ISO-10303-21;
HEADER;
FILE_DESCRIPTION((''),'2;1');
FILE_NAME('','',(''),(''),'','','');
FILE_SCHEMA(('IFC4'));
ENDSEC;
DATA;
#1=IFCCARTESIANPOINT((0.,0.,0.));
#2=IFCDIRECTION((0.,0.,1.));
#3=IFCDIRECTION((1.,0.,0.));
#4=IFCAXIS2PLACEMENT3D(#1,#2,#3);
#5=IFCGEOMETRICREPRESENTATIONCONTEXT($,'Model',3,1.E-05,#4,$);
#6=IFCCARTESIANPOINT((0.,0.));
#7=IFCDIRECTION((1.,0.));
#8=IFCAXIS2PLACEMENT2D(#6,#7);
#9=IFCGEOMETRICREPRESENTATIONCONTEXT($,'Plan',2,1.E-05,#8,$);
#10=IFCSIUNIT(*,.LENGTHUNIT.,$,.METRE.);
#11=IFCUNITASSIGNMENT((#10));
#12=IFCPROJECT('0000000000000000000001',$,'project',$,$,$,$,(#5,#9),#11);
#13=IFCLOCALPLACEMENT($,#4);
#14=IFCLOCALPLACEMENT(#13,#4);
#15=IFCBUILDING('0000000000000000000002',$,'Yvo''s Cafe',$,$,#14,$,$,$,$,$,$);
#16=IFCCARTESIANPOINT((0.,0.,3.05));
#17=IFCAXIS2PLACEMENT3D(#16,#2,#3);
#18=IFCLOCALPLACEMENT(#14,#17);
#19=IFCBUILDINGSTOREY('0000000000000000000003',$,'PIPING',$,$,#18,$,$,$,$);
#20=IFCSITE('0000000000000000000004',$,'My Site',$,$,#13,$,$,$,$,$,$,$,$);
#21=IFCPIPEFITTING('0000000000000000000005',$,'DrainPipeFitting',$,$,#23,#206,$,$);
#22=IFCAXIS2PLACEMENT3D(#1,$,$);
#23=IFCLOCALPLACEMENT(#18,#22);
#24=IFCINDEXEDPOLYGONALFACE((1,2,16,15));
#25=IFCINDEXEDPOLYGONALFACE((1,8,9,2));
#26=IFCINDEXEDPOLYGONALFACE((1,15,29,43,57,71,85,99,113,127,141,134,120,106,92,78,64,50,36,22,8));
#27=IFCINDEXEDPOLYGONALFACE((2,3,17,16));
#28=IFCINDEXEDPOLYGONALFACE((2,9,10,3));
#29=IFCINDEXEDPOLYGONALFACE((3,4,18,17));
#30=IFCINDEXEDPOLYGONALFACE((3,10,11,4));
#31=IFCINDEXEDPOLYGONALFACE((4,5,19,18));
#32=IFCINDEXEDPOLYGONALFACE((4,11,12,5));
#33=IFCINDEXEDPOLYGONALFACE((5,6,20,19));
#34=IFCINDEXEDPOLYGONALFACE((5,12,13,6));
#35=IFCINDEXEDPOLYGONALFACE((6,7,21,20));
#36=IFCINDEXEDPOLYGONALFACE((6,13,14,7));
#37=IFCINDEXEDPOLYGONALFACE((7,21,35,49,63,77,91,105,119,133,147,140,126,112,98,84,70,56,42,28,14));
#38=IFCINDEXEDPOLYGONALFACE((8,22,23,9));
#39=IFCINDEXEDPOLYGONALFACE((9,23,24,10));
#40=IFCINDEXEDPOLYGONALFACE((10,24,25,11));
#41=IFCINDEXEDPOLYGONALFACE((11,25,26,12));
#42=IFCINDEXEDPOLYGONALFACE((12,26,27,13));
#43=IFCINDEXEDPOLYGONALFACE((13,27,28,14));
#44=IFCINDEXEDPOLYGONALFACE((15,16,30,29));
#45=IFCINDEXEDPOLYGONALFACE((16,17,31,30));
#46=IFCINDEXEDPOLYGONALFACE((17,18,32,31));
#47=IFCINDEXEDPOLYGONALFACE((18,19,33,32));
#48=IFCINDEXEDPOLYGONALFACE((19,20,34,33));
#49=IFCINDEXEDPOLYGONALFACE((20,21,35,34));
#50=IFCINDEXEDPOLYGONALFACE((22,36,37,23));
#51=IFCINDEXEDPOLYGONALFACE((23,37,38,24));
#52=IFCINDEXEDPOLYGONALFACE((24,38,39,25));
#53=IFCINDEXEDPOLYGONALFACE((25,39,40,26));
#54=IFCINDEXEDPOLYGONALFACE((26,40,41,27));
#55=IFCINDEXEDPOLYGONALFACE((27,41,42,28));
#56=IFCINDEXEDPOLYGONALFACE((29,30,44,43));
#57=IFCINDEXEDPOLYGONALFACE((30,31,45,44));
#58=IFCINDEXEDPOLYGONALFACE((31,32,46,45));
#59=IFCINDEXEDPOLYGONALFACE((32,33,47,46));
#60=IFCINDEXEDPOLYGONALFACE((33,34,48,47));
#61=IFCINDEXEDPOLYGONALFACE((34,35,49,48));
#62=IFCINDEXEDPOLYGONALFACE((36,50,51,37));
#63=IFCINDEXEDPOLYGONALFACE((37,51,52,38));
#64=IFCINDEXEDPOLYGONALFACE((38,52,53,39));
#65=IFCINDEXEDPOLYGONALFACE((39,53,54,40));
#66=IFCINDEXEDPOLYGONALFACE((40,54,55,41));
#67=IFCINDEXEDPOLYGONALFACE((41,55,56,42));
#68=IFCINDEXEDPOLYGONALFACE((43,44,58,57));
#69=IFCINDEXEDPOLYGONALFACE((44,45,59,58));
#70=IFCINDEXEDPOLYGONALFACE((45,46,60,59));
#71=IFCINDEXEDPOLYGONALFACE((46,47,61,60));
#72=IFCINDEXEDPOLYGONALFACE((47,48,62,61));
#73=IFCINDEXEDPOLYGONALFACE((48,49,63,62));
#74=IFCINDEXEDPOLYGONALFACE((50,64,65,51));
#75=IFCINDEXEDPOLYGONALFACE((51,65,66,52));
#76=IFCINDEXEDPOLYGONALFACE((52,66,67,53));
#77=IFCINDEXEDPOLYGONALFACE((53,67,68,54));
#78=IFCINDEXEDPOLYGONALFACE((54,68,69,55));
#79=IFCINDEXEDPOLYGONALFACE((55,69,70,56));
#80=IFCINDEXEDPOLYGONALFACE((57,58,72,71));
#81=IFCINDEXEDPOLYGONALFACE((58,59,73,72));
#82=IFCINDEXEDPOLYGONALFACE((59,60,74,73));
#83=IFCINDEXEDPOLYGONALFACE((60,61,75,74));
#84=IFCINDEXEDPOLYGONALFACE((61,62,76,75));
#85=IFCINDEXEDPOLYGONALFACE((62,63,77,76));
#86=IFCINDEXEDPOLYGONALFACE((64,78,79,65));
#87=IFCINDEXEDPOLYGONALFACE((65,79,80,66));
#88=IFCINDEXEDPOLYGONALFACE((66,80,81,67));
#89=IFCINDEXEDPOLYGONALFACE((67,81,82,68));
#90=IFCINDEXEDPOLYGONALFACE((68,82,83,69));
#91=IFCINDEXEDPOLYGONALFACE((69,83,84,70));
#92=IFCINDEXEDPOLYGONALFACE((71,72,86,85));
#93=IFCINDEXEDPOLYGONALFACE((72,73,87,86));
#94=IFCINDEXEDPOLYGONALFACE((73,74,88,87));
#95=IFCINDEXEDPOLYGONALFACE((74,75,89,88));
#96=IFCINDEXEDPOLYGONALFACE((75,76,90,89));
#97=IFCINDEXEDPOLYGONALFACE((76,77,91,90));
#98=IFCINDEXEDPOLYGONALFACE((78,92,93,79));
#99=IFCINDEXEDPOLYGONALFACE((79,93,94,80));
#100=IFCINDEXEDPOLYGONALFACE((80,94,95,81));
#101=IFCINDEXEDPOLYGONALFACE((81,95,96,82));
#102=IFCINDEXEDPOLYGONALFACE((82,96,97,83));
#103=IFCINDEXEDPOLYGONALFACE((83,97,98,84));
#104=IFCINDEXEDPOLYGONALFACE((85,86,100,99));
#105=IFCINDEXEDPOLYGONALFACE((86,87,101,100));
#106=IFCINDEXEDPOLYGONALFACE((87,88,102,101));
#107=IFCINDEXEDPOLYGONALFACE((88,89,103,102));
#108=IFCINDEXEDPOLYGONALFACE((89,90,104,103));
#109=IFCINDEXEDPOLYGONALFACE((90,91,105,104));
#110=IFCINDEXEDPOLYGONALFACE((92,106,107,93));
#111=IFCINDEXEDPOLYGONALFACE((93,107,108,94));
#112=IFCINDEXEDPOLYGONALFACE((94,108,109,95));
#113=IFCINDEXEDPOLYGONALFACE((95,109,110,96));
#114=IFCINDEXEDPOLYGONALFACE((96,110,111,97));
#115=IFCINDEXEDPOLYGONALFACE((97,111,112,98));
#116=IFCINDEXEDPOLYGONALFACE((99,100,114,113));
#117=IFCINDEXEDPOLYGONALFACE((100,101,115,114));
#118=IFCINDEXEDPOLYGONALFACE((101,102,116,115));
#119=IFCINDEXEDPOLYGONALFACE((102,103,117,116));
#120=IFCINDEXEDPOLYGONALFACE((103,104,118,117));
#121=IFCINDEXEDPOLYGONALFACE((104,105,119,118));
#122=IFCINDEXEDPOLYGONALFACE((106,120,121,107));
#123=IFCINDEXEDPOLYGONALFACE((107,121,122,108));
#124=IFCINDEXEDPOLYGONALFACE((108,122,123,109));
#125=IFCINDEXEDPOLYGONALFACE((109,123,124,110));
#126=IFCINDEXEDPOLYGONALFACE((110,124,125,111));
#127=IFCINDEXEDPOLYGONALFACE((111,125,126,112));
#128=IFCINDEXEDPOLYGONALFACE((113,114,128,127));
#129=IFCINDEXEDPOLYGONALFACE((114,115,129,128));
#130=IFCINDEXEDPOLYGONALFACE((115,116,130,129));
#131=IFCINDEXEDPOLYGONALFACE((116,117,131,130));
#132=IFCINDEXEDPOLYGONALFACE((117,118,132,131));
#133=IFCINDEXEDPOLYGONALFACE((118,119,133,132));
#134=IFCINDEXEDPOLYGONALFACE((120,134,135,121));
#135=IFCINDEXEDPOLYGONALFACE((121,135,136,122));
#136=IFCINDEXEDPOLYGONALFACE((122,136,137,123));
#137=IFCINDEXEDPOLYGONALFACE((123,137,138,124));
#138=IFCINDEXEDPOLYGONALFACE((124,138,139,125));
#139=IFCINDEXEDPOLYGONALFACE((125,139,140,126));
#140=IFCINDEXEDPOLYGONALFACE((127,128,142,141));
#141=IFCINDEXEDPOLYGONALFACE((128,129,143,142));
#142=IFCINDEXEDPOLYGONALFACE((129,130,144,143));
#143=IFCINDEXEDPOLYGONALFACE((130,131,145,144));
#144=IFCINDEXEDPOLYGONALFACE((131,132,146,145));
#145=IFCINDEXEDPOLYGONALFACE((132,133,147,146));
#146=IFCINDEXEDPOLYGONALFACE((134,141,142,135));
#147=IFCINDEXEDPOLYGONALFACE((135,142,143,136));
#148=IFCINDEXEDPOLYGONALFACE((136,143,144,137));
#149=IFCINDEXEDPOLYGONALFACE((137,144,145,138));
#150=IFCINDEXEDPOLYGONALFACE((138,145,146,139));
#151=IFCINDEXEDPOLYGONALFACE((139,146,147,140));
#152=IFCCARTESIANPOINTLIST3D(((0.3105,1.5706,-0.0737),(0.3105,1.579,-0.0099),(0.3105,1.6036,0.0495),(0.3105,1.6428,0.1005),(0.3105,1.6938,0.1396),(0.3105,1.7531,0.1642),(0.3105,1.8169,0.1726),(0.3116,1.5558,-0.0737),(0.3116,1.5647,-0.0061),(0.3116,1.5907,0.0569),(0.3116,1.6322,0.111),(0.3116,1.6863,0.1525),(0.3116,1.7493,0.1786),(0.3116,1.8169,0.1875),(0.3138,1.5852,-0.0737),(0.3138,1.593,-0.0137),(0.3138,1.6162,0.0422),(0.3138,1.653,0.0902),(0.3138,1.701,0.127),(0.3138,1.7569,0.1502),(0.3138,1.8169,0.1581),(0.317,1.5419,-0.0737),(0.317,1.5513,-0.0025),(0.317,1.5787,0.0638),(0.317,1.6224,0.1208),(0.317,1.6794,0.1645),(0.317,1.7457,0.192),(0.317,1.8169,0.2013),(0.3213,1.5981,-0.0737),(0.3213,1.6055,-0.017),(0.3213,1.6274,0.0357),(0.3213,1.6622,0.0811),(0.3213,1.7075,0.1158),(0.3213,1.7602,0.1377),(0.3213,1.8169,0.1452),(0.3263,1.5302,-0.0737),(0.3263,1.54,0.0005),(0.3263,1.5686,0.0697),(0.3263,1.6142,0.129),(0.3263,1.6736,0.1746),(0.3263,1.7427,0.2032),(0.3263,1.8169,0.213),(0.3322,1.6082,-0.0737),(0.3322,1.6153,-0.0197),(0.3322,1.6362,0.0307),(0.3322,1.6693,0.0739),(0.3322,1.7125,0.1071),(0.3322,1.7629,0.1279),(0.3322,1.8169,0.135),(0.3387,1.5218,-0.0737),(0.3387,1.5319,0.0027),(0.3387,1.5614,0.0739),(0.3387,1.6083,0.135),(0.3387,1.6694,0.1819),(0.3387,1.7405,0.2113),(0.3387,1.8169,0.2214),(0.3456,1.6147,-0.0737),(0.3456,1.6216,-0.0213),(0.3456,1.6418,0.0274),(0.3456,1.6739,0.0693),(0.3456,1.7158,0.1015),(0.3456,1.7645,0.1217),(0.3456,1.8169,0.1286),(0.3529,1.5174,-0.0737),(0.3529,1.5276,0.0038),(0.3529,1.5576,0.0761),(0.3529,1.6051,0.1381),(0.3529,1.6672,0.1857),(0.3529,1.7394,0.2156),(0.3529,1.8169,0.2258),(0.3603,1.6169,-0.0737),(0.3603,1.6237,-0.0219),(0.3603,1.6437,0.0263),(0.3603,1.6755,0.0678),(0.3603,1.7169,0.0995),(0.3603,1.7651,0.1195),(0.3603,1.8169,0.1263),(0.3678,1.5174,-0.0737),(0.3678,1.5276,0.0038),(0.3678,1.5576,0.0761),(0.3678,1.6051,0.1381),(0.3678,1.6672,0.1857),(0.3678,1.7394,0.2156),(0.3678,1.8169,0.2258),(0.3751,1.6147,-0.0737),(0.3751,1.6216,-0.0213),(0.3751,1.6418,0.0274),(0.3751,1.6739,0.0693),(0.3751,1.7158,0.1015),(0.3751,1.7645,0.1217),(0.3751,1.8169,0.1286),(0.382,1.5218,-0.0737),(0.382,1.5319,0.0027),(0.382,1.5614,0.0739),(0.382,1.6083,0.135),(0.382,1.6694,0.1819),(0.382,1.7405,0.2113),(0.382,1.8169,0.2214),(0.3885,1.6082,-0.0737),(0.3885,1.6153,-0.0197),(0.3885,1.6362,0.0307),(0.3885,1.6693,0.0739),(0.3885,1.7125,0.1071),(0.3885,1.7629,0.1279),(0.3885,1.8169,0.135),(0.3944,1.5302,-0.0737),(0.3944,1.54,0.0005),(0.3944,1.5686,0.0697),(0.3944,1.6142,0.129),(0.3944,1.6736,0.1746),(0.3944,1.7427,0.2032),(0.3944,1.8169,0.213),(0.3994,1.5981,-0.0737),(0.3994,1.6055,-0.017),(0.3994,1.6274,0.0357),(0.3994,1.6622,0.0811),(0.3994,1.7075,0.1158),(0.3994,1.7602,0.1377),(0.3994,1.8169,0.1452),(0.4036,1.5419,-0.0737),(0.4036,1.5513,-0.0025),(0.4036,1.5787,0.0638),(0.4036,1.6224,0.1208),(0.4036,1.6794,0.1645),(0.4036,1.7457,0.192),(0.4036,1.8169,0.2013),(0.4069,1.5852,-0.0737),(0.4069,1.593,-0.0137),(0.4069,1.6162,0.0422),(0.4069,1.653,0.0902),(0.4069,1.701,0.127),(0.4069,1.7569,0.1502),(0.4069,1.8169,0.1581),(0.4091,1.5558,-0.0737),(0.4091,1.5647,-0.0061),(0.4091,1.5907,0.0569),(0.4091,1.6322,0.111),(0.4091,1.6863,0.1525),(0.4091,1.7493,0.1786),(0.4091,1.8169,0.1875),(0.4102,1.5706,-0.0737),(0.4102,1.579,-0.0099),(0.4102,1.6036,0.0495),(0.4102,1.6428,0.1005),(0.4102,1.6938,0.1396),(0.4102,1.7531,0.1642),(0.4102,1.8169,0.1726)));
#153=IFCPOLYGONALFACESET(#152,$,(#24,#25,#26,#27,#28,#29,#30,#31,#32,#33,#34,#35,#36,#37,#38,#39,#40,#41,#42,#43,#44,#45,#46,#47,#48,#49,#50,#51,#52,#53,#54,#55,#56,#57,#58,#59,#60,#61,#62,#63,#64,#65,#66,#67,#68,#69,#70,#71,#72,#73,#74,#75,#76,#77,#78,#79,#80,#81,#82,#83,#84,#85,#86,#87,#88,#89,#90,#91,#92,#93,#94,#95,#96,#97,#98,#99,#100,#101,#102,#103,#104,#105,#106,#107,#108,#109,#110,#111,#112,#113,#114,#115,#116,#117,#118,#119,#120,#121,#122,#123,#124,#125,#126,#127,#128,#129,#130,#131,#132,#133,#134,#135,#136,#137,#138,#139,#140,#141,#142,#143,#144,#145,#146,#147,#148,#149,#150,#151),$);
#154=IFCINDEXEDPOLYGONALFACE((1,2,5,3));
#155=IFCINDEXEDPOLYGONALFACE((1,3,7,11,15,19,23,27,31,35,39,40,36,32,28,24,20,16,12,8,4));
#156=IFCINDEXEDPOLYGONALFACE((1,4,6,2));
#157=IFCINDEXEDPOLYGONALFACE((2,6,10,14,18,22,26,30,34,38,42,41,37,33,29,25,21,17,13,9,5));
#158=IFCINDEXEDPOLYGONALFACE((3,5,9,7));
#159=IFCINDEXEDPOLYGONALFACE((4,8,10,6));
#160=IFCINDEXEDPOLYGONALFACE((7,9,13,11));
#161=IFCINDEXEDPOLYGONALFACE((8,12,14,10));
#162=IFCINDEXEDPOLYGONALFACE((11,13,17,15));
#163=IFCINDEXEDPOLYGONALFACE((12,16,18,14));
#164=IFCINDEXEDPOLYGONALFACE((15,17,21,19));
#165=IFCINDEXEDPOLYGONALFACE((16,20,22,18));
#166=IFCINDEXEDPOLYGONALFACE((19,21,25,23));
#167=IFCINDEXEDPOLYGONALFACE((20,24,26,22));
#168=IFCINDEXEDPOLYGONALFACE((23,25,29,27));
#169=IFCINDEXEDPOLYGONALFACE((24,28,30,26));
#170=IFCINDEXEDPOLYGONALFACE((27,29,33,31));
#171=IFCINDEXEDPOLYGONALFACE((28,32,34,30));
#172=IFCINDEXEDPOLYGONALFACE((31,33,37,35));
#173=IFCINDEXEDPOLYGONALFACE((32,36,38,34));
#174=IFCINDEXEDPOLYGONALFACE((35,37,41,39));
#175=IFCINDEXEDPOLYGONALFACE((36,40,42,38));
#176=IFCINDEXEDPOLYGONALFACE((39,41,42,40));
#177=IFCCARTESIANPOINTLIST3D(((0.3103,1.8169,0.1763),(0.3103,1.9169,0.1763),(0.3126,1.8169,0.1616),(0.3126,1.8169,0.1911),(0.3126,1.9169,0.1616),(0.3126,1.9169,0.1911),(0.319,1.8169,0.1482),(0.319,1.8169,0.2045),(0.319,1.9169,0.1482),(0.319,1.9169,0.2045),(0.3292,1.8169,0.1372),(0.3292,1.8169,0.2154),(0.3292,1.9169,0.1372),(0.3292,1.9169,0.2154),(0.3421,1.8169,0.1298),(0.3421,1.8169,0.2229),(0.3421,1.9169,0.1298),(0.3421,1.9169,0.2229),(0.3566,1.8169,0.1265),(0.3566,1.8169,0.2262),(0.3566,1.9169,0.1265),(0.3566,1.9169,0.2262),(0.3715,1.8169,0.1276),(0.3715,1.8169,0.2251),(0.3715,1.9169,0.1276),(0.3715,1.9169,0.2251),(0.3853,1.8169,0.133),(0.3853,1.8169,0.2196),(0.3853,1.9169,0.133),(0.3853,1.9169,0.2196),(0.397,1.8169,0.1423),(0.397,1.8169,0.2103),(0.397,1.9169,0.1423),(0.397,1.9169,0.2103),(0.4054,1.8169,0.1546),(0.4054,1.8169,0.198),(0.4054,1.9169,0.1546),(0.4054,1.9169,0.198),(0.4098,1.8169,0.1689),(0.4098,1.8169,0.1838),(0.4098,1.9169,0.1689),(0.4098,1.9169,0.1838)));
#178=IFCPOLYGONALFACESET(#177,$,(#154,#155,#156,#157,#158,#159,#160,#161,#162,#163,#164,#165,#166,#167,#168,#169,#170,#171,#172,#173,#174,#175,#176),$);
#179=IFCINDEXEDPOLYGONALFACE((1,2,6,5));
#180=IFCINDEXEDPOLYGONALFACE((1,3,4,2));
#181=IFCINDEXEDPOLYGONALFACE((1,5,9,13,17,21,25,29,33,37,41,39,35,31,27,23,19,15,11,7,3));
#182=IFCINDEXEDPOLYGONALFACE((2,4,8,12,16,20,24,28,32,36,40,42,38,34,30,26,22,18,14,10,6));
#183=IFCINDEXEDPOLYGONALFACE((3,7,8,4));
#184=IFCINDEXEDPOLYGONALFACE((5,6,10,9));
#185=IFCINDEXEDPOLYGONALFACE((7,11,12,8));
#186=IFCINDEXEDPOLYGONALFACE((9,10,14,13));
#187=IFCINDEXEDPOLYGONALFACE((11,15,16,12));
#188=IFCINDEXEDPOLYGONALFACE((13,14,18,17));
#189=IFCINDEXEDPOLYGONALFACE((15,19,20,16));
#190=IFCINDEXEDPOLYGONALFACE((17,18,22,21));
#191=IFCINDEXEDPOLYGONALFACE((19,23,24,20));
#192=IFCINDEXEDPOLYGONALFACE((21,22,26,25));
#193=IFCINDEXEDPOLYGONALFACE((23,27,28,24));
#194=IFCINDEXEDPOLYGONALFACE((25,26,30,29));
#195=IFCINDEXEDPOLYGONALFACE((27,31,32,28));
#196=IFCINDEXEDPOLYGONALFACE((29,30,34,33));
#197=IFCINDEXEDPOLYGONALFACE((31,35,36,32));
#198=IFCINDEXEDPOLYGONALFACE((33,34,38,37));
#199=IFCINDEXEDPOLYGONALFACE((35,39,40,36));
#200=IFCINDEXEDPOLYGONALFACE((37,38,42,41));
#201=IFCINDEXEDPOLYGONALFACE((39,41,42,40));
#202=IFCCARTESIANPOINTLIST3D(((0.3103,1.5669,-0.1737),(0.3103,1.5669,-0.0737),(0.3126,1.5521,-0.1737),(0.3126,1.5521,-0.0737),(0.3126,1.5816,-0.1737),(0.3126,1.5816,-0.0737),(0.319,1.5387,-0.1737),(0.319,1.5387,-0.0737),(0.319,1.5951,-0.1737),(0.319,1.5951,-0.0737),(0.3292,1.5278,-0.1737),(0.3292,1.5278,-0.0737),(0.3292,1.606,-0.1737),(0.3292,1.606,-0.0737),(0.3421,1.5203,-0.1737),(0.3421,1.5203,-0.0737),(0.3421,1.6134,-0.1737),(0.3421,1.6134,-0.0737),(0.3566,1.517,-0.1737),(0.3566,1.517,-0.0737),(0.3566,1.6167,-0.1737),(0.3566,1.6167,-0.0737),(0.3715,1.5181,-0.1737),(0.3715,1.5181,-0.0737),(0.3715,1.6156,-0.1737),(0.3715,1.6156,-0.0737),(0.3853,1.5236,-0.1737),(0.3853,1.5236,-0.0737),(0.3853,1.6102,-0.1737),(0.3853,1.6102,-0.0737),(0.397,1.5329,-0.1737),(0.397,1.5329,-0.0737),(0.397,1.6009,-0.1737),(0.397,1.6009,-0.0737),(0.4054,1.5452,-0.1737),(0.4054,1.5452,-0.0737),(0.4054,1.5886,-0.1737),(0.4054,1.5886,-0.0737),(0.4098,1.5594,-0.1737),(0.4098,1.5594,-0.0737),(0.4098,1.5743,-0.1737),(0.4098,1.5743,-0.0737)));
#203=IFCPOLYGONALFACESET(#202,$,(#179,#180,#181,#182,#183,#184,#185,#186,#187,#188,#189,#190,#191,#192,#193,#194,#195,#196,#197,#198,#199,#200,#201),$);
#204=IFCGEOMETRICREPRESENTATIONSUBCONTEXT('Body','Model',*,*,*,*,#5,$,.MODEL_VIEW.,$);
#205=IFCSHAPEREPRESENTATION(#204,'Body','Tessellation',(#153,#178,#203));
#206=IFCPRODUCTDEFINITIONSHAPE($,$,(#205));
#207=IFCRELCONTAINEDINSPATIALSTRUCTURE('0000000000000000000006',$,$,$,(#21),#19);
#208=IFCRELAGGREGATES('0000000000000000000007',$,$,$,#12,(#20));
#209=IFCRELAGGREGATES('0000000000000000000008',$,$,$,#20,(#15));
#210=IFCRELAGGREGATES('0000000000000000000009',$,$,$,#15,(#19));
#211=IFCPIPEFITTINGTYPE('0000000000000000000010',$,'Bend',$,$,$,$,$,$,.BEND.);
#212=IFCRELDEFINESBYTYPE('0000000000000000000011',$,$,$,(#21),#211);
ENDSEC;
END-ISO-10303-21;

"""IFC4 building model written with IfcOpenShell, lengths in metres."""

from ifc_helpers import new_model, entity, si_unit, frame, origin_with_axes, origin_2d_with_axis, place, context, subcontext, project, spatial, circle, extrude, source, transform, mapped, type_object, type_shapes, element, save


model = new_model("IFC4")

# Units and contexts
model_context = context("Model", 3, precision=1e-05, world=origin_with_axes())
plan_context = context("Plan", 2, precision=1e-05, world=origin_2d_with_axis())
body_context = subcontext(model_context, "Body", "Model", "MODEL_VIEW")
ifc_project = project(units=[si_unit("LENGTHUNIT", "METRE")], contexts=[model_context, plan_context])

# Site, building, storey
site_placement = place(None, origin_with_axes())
site = spatial("IfcSite", under=ifc_project, at=site_placement, Name="My Site")
building_placement = place(site_placement, origin_with_axes())
building = spatial("IfcBuilding", under=site, at=building_placement, Name="Yvo's Cafe")
storey_placement = place(building_placement, frame((0.0, 0.0, 3.05), z_axis=(0.0, 0.0, 1.0), x_axis=(1.0, 0.0, 0.0)))
storey = spatial("IfcBuildingStorey", under=building, at=storey_placement, Name="PIPING")

# Shared definitions
pipe_fitting_type_1 = type_object("IfcPipeFittingType", Name="Bend", PredefinedType="BEND")
shared_shape_1 = source(origin_with_axes(), body_context, "Body", "SolidModel", [
    entity("IfcSweptDiskSolid", entity("IfcIndexedPolyCurve", entity("IfcCartesianPointList3D", [[0.0, 0.0, -0.1], [0.0, -0.0732, -0.2768], [0.0, -0.25, -0.35]]), [entity("IfcArcIndex", [1, 2, 3])]), 0.05),
    extrude(circle(Radius=0.05), origin_with_axes(), (0.0, 0.0, -1.0), 0.1),
    extrude(circle(Radius=0.05), frame((0.0, -0.25, -0.35), z_axis=(0.0, -1.0, 0.0), x_axis=(1.0, 0.0, 0.0)), (0.0, 0.0, 1.0), 0.1),
])
type_shapes(pipe_fitting_type_1, [shared_shape_1])

# Pipe fitting
for number, where, z_axis, x_axis, name in (
    (1, (0.3603, 1.9169, 0.1763), (0.0, 1.0, 0.0), (-1.0, 0.0, 0.0), "DrainPipeFitting"),
):
    element("IfcPipeFitting", number, at=place(storey_placement, frame(where, z_axis=z_axis, x_axis=x_axis)), inside=storey, type_object=pipe_fitting_type_1, Name=name, context=body_context, shape_type="MappedRepresentation", body=[
        mapped(shared_shape_1, transform((0.0, 0.0, 0.0), x_axis=(1.0, 0.0, 0.0), y_axis=(0.0, 1.0, 0.0), z_axis=(0.0, 0.0, 1.0), scale=1.0)),
    ])

save(model, "model.ifc")
